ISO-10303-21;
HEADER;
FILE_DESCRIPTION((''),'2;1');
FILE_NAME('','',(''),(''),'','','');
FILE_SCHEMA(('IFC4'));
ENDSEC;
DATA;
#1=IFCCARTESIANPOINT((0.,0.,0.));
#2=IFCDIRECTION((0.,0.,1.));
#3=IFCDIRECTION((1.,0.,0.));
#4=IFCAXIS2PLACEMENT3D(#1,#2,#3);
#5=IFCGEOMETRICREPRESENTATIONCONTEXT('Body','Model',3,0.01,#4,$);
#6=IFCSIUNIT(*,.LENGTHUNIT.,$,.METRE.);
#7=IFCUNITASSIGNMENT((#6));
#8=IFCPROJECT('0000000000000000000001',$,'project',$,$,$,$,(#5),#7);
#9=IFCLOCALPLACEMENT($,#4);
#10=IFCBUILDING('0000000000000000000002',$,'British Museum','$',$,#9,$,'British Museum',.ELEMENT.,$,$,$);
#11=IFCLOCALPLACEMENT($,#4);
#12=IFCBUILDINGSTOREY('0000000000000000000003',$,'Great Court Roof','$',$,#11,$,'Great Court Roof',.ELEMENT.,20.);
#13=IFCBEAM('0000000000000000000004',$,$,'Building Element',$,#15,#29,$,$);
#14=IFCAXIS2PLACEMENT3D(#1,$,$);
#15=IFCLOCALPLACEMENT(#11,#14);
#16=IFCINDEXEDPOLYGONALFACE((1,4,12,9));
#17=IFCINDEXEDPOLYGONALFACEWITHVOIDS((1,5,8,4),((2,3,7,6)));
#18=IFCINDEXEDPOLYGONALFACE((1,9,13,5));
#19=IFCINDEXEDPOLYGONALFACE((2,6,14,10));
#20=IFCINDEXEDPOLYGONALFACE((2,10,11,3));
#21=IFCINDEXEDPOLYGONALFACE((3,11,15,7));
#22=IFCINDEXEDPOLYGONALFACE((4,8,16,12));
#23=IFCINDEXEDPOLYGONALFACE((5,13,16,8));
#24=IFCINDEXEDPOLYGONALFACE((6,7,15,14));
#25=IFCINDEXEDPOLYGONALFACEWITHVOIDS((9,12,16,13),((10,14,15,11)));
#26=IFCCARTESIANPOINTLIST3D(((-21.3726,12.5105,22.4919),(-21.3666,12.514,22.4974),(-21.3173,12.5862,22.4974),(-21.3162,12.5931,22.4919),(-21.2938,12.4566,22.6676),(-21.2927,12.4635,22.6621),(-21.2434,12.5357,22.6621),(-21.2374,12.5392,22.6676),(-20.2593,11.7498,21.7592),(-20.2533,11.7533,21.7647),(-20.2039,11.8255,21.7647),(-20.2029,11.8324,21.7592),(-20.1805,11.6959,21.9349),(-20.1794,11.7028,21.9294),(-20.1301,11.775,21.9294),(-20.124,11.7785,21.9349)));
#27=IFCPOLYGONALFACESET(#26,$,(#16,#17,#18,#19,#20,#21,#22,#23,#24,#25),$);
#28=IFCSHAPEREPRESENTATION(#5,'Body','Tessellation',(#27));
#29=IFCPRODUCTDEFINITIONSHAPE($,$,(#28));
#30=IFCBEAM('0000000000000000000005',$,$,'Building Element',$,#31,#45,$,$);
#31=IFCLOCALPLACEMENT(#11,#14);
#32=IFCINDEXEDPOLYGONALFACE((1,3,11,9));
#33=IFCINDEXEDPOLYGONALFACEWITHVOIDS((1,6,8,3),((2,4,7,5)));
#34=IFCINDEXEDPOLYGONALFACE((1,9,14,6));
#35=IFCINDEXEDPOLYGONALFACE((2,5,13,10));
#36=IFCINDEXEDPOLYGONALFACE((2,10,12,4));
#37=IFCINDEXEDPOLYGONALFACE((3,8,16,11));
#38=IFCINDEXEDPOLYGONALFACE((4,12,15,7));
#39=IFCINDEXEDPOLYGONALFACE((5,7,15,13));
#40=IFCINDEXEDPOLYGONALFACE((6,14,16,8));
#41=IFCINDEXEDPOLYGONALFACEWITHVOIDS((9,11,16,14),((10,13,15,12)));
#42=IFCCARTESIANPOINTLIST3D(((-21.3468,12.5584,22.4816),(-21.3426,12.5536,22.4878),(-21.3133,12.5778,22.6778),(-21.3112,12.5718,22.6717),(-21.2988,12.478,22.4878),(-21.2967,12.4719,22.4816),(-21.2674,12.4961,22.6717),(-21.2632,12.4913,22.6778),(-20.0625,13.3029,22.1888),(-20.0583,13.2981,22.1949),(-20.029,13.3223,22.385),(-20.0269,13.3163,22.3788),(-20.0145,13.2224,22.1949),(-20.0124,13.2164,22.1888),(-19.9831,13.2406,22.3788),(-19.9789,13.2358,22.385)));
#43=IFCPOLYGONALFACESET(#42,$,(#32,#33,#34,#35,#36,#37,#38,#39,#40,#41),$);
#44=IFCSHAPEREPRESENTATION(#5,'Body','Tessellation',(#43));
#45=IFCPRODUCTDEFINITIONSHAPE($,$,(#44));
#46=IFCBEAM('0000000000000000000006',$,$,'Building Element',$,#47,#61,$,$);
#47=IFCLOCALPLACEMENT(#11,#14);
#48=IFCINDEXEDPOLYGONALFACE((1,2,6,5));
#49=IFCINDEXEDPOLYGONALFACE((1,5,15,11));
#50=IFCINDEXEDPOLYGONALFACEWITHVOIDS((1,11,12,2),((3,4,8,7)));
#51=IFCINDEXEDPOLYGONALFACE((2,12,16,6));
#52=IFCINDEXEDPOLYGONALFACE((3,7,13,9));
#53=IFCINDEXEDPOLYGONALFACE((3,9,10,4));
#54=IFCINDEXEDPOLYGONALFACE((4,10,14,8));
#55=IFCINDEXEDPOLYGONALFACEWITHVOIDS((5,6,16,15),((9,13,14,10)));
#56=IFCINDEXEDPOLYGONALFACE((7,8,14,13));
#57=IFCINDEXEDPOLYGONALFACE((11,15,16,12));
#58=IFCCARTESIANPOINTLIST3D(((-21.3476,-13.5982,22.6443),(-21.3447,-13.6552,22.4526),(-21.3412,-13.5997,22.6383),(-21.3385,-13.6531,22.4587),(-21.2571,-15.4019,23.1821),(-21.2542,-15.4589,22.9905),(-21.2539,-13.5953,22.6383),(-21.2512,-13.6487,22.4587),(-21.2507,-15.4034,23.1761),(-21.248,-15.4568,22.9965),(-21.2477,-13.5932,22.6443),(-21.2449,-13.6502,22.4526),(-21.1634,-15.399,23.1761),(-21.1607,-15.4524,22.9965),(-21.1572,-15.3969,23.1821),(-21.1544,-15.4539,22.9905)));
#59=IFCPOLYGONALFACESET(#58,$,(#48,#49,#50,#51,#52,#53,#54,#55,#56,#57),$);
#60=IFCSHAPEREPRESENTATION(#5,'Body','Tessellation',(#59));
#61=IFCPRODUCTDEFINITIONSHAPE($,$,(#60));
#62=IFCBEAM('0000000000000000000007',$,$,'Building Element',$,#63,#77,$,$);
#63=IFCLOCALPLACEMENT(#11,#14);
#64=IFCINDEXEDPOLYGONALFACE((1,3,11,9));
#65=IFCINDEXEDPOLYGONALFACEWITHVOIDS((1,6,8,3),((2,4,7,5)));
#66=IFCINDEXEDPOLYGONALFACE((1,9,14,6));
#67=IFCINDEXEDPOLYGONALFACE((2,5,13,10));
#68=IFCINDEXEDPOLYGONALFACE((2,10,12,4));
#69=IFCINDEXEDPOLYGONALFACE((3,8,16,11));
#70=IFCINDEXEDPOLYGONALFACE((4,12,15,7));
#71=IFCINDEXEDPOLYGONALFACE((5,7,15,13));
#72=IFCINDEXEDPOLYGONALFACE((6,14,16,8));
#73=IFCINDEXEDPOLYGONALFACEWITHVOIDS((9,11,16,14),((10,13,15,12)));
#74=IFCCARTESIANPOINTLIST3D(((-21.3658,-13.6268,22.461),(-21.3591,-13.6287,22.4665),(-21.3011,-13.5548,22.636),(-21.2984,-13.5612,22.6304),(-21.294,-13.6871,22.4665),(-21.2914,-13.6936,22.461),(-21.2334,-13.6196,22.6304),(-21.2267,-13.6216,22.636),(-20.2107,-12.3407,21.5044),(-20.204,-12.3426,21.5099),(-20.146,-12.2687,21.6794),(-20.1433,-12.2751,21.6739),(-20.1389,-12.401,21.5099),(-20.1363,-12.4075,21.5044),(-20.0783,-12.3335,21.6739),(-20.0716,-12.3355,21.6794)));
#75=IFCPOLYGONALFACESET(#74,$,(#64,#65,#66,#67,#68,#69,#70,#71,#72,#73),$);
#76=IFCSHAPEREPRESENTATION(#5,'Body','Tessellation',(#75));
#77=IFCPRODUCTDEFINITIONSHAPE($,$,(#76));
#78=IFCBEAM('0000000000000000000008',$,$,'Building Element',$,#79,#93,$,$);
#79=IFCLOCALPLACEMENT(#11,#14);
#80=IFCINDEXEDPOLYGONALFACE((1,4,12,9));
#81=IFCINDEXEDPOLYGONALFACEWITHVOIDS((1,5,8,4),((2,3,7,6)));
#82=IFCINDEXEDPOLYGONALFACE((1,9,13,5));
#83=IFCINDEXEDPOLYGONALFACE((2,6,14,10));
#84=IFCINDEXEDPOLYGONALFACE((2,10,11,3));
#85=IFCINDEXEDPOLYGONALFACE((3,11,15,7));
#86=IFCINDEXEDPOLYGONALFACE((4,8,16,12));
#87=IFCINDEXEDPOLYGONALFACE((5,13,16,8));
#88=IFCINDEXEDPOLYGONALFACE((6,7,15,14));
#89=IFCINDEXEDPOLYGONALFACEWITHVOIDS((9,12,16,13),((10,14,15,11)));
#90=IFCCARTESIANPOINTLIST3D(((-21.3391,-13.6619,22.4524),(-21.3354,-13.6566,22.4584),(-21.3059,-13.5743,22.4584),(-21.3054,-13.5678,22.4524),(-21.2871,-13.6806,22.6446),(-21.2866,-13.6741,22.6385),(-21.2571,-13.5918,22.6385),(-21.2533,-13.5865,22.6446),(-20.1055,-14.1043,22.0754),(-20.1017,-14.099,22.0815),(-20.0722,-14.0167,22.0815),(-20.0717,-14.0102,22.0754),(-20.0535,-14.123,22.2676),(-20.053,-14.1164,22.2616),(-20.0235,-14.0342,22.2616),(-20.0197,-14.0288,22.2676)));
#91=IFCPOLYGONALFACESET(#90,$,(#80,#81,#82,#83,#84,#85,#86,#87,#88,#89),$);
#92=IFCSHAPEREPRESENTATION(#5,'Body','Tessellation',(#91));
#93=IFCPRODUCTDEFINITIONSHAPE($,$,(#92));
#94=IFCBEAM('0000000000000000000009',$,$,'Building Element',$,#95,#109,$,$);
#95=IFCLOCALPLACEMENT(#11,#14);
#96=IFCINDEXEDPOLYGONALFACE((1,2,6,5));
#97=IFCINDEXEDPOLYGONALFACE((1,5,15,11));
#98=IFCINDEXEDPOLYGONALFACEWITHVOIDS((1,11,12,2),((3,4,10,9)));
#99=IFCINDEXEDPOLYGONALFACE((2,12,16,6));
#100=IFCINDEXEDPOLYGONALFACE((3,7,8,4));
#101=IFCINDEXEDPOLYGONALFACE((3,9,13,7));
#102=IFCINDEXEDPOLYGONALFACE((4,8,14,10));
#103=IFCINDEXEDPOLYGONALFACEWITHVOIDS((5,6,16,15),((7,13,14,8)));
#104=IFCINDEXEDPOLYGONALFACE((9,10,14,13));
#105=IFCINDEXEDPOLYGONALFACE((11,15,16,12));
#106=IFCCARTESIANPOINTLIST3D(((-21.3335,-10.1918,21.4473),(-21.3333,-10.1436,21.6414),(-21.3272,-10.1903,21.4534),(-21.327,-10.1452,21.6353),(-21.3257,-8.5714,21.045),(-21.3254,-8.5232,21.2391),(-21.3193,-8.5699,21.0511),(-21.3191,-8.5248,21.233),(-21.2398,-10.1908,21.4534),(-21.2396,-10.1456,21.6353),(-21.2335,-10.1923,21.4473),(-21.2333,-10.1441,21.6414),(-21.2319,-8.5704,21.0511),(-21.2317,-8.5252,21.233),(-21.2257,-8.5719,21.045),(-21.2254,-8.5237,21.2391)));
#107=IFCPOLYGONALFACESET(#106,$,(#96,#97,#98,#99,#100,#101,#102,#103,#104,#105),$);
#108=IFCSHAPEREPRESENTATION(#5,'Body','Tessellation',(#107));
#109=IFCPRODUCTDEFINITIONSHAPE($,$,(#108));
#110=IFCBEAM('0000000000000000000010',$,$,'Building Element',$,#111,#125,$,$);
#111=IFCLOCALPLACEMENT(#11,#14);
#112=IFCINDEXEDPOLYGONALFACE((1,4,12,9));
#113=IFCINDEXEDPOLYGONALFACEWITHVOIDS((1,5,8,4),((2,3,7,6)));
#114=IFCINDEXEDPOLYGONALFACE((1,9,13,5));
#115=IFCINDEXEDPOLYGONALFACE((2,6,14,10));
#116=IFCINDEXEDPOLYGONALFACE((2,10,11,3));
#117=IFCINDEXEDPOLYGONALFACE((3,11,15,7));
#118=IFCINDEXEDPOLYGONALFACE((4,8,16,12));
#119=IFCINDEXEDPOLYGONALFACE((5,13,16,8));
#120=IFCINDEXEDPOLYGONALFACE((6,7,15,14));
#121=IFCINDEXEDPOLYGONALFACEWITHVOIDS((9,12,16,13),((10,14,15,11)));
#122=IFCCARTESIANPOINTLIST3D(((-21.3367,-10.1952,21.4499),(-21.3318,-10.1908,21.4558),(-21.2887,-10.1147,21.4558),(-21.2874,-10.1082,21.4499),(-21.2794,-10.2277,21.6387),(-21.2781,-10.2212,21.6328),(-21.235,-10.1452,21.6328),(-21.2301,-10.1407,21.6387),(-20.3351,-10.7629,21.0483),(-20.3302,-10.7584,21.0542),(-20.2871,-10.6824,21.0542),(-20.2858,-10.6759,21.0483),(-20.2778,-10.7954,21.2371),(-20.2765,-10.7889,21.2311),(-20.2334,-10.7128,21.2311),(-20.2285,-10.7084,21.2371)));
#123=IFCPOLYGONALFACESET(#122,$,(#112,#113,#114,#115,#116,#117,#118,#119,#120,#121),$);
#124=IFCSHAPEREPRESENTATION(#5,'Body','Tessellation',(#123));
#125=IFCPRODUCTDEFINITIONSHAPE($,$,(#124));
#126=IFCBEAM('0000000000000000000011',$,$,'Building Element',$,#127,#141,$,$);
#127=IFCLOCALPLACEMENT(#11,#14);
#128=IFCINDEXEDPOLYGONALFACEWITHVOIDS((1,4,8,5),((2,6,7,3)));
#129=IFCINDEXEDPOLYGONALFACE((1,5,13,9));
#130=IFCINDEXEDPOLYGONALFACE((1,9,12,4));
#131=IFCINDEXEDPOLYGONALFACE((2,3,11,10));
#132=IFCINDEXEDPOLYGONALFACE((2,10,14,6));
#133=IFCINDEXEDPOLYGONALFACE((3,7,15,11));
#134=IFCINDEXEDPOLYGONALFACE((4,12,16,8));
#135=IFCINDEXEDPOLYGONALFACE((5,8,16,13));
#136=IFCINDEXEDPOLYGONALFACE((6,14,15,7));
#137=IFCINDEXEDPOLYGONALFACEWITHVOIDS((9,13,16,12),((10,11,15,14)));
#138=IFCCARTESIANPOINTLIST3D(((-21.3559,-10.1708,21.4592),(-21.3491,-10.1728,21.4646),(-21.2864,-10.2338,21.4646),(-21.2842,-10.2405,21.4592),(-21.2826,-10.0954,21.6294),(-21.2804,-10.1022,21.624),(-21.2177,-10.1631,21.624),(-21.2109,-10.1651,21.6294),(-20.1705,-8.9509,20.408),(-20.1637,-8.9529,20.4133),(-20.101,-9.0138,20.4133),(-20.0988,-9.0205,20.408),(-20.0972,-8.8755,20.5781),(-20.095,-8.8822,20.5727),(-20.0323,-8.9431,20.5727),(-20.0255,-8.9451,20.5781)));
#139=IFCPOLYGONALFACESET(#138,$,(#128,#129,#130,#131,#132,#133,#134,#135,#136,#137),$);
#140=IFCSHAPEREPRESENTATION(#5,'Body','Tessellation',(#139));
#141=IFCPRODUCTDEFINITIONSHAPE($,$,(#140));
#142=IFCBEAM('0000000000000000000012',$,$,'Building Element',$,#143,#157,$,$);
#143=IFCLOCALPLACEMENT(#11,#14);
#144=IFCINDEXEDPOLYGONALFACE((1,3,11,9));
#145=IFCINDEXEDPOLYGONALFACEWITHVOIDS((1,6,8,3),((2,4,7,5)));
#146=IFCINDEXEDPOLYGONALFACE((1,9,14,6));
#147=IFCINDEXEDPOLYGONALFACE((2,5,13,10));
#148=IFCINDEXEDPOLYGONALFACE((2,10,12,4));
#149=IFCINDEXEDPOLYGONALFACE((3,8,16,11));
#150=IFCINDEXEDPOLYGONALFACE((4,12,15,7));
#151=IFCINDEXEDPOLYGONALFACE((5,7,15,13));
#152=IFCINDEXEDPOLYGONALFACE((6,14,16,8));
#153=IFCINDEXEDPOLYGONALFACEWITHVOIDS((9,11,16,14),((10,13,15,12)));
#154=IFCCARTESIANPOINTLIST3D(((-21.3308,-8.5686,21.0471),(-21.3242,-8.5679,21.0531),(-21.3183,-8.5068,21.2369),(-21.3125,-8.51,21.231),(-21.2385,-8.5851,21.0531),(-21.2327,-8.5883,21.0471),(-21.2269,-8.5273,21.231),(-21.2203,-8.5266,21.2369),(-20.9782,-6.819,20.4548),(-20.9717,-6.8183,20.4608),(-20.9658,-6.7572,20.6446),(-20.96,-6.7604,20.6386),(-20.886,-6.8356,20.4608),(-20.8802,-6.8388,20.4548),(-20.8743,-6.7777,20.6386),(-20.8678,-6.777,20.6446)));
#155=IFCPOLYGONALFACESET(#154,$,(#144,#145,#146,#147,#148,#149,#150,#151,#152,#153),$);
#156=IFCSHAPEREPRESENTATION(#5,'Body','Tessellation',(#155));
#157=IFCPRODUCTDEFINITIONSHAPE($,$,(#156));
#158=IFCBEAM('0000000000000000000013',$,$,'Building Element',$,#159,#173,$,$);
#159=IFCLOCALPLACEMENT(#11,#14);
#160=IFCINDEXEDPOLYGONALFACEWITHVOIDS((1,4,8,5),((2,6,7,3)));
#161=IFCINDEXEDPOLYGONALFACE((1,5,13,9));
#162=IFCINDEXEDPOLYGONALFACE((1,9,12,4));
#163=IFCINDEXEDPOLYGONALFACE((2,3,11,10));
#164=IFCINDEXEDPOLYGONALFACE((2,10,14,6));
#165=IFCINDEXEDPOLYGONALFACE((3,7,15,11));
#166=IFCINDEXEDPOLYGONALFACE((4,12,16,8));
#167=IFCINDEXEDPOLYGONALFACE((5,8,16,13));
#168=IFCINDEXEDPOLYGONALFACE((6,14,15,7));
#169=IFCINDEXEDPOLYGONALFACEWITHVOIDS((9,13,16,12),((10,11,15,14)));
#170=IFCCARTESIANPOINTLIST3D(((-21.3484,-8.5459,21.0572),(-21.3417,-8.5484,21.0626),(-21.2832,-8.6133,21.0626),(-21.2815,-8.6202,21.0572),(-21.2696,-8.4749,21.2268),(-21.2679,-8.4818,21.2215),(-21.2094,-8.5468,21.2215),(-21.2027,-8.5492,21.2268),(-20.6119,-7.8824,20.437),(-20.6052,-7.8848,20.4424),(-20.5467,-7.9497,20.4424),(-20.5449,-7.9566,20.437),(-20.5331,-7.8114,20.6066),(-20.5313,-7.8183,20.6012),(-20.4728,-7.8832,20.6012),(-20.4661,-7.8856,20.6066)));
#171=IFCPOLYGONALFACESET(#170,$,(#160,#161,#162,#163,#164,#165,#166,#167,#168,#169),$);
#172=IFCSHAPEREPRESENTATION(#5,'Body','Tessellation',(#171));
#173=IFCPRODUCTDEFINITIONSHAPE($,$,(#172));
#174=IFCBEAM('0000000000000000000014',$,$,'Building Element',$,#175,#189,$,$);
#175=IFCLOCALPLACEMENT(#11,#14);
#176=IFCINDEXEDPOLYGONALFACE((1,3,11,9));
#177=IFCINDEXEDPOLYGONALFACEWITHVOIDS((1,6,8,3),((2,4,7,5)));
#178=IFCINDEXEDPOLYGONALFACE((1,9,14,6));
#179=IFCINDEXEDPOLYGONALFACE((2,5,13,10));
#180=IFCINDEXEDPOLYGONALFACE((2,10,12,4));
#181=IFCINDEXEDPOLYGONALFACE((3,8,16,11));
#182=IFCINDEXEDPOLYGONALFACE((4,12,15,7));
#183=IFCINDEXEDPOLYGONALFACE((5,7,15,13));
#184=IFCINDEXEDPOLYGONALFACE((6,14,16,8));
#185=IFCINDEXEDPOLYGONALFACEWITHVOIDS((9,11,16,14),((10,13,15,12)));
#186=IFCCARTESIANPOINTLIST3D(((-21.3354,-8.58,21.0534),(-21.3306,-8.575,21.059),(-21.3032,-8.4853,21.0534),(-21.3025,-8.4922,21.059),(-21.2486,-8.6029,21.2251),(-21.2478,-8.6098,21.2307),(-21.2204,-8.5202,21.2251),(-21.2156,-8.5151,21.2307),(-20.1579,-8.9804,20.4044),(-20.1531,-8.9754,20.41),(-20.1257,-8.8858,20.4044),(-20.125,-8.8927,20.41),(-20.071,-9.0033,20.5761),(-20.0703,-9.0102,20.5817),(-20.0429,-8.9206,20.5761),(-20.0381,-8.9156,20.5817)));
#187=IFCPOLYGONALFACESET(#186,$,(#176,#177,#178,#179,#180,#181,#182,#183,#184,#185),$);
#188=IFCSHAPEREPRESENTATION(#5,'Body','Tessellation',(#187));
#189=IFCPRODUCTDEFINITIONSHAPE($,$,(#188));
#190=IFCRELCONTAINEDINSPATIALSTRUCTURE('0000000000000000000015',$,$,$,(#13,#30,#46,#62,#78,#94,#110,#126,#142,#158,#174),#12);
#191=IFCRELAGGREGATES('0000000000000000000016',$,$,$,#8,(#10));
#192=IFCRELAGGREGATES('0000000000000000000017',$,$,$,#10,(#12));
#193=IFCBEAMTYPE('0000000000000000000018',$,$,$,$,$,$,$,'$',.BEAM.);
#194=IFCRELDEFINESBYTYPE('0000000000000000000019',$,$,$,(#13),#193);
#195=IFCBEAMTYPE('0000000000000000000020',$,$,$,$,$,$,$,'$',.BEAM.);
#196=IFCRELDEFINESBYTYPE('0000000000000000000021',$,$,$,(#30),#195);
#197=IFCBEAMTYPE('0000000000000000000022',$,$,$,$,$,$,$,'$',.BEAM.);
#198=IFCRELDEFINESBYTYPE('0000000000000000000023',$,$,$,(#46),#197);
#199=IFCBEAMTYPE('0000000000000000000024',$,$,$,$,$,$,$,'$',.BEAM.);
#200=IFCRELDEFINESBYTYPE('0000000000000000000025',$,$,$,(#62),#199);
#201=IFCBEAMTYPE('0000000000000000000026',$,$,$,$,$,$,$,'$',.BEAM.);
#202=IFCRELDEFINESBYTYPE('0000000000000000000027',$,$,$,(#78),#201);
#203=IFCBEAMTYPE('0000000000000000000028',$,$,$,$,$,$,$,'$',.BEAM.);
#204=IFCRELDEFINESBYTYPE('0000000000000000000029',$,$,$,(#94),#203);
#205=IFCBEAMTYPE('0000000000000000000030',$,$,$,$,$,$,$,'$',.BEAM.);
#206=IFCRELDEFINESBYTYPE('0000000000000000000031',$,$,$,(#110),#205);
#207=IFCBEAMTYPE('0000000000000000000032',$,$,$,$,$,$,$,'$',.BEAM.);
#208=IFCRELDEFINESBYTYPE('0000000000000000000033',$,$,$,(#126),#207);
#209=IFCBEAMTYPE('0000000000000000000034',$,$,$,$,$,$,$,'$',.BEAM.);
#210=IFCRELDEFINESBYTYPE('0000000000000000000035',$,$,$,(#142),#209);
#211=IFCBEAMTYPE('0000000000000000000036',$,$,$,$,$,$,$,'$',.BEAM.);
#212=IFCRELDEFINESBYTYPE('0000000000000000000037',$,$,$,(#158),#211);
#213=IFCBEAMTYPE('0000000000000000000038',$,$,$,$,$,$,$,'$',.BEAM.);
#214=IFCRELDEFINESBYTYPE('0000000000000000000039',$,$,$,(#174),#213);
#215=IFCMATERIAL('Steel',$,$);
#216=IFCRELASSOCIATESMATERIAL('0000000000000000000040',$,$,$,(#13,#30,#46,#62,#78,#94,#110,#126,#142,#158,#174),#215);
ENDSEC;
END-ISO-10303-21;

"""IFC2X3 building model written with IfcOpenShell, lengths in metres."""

from ifc_helpers import new_model, si_unit, frame, origin_with_axes, origin_2d, place, context, project, spatial, hollow_rectangle, extrude, material, type_object, element, save


model = new_model("IFC2X3")

# Units and contexts
model_context = context("Model", 3, precision=0.01, world=origin_with_axes(), identifier="Body")
ifc_project = project(units=[si_unit("LENGTHUNIT", "METRE")], contexts=[model_context])

# Building, storey
building_placement = place(None, origin_with_axes())
building = spatial("IfcBuilding", under=ifc_project, at=building_placement, Name="British Museum", Description="$", LongName="British Museum", CompositionType="ELEMENT")
storey_placement = place(None, origin_with_axes())
storey = spatial("IfcBuildingStorey", under=building, at=storey_placement, Name="Great Court Roof", Description="$", LongName="Great Court Roof", CompositionType="ELEMENT", Elevation=20.0)

# Beams
ifc_material = material(Name="Steel")
beam_type_1 = type_object("IfcBeamType", ElementType="$", PredefinedType="BEAM")
beam_1_placement = place(None, origin_with_axes())
element("IfcBeam", 1, at=beam_1_placement, inside=storey, type_object=beam_type_1, material=ifc_material, Description="Building Element", context=model_context, shape_type="SweptSolid", body=[
    extrude(hollow_rectangle(XDim=0.1, YDim=0.2, WallThickness=0.0063, InnerFilletRadius=-0.0063, OuterFilletRadius=0.0, at=origin_2d()), frame((-21.305, 12.5249, 22.5797), z_axis=(0.725481, -0.495704, -0.477446), x_axis=(0.564159, 0.825666, 0.0)), (0.0, 0.0, 1.0), 1.5346),
])
beam_type_2 = type_object("IfcBeamType", ElementType="$", PredefinedType="BEAM")
beam_2_placement = place(None, origin_with_axes())
element("IfcBeam", 2, at=beam_2_placement, inside=storey, type_object=beam_type_2, material=ifc_material, Description="Building Element", context=model_context, shape_type="SweptSolid", body=[
    extrude(hollow_rectangle(XDim=0.1, YDim=0.2, WallThickness=0.0063, InnerFilletRadius=-0.0063, OuterFilletRadius=0.0, at=origin_2d()), frame((-21.305, 12.5249, 22.5797), z_axis=(0.84879, 0.492026, -0.193562), x_axis=(-0.501511, 0.865151, 0.0)), (0.0, 0.0, 1.0), 1.5131),
])
beam_type_3 = type_object("IfcBeamType", ElementType="$", PredefinedType="BEAM")
beam_3_placement = place(None, origin_with_axes())
element("IfcBeam", 3, at=beam_3_placement, inside=storey, type_object=beam_type_3, material=ifc_material, Description="Building Element", context=model_context, shape_type="SweptSolid", body=[
    extrude(hollow_rectangle(XDim=0.1, YDim=0.2, WallThickness=0.0063, InnerFilletRadius=-0.0063, OuterFilletRadius=0.0, at=origin_2d()), frame((-21.2962, -13.6242, 22.5485), z_axis=(0.048022, -0.957196, 0.285428), x_axis=(0.998744, 0.050106, 0.0)), (0.0, 0.0, 1.0), 1.8844),
])
beam_type_4 = type_object("IfcBeamType", ElementType="$", PredefinedType="BEAM")
beam_4_placement = place(None, origin_with_axes())
element("IfcBeam", 4, at=beam_4_placement, inside=storey, type_object=beam_type_4, material=ifc_material, Description="Building Element", context=model_context, shape_type="SweptSolid", body=[
    extrude(hollow_rectangle(XDim=0.1, YDim=0.2, WallThickness=0.0063, InnerFilletRadius=-0.0063, OuterFilletRadius=0.0, at=origin_2d()), frame((-21.2962, -13.6242, 22.5485), z_axis=(0.584654, 0.650973, -0.484162), x_axis=(-0.743988, 0.668193, 0.0)), (0.0, 0.0, 1.0), 1.9757),
])
beam_type_5 = type_object("IfcBeamType", ElementType="$", PredefinedType="BEAM")
beam_5_placement = place(None, origin_with_axes())
element("IfcBeam", 5, at=beam_5_placement, inside=storey, type_object=beam_type_5, material=ifc_material, Description="Building Element", context=model_context, shape_type="SweptSolid", body=[
    extrude(hollow_rectangle(XDim=0.1, YDim=0.2, WallThickness=0.0063, InnerFilletRadius=-0.0063, OuterFilletRadius=0.0, at=origin_2d()), frame((-21.2962, -13.6242, 22.5485), z_axis=(0.904637, -0.324403, -0.276397), x_axis=(0.337553, 0.941307, 0.0)), (0.0, 0.0, 1.0), 1.3637),
])
beam_type_6 = type_object("IfcBeamType", ElementType="$", PredefinedType="BEAM")
beam_6_placement = place(None, origin_with_axes())
element("IfcBeam", 6, at=beam_6_placement, inside=storey, type_object=beam_type_6, material=ifc_material, Description="Building Element", context=model_context, shape_type="SweptSolid", body=[
    extrude(hollow_rectangle(XDim=0.1, YDim=0.2, WallThickness=0.0063, InnerFilletRadius=-0.0063, OuterFilletRadius=0.0, at=origin_2d()), frame((-21.2834, -10.168, 21.5443), z_axis=(0.004715, 0.970527, -0.240948), x_axis=(-0.999988, 0.004859, 0.0)), (0.0, 0.0, 1.0), 1.6696),
])
beam_type_7 = type_object("IfcBeamType", ElementType="$", PredefinedType="BEAM")
beam_7_placement = place(None, origin_with_axes())
element("IfcBeam", 7, at=beam_7_placement, inside=storey, type_object=beam_type_7, material=ifc_material, Description="Building Element", context=model_context, shape_type="SweptSolid", body=[
    extrude(hollow_rectangle(XDim=0.1, YDim=0.2, WallThickness=0.0063, InnerFilletRadius=-0.0063, OuterFilletRadius=0.0, at=origin_2d()), frame((-21.2834, -10.168, 21.5443), z_axis=(0.821449, -0.465538, -0.329387), x_axis=(0.493053, 0.869999, 0.0)), (0.0, 0.0, 1.0), 1.2194),
])
beam_type_8 = type_object("IfcBeamType", ElementType="$", PredefinedType="BEAM")
beam_8_placement = place(None, origin_with_axes())
element("IfcBeam", 8, at=beam_8_placement, inside=storey, type_object=beam_type_8, material=ifc_material, Description="Building Element", context=model_context, shape_type="SweptSolid", body=[
    extrude(hollow_rectangle(XDim=0.1, YDim=0.2, WallThickness=0.0063, InnerFilletRadius=-0.0063, OuterFilletRadius=0.0, at=origin_2d()), frame((-21.2834, -10.168, 21.5443), z_axis=(0.592799, 0.610084, -0.525725), x_axis=(-0.717194, 0.696874, 0.0)), (0.0, 0.0, 1.0), 1.9997),
])
beam_type_9 = type_object("IfcBeamType", ElementType="$", PredefinedType="BEAM")
beam_9_placement = place(None, origin_with_axes())
element("IfcBeam", 9, at=beam_9_placement, inside=storey, type_object=beam_type_9, material=ifc_material, Description="Building Element", context=model_context, shape_type="SweptSolid", body=[
    extrude(hollow_rectangle(XDim=0.1, YDim=0.2, WallThickness=0.0063, InnerFilletRadius=-0.0063, OuterFilletRadius=0.0, at=origin_2d()), frame((-21.2755, -8.5476, 21.142), z_axis=(0.187473, 0.930396, -0.314989), x_axis=(-0.980297, 0.197528, 0.0)), (0.0, 0.0, 1.0), 1.8805),
])
beam_type_10 = type_object("IfcBeamType", ElementType="$", PredefinedType="BEAM")
beam_10_placement = place(None, origin_with_axes())
element("IfcBeam", 10, at=beam_10_placement, inside=storey, type_object=beam_type_10, material=ifc_material, Description="Building Element", context=model_context, shape_type="SweptSolid", body=[
    extrude(hollow_rectangle(XDim=0.1, YDim=0.2, WallThickness=0.0063, InnerFilletRadius=-0.0063, OuterFilletRadius=0.0, at=origin_2d()), frame((-21.2755, -8.5476, 21.142), z_axis=(0.629842, 0.567445, -0.530382), x_axis=(-0.669348, 0.742949, 0.0)), (0.0, 0.0, 1.0), 1.1694),
])
beam_type_11 = type_object("IfcBeamType", ElementType="$", PredefinedType="BEAM")
beam_11_placement = place(None, origin_with_axes())
element("IfcBeam", 11, at=beam_11_placement, inside=storey, type_object=beam_type_11, material=ifc_material, Description="Building Element", context=model_context, shape_type="SweptSolid", body=[
    extrude(hollow_rectangle(XDim=0.1, YDim=0.2, WallThickness=0.0063, InnerFilletRadius=-0.0063, OuterFilletRadius=0.0, at=origin_2d()), frame((-21.2755, -8.5476, 21.142), z_axis=(0.839359, -0.285432, -0.462608), x_axis=(0.321953, 0.946755, 0.0)), (0.0, 0.0, 1.0), 1.4029),
])

save(model, "model.ifc")
